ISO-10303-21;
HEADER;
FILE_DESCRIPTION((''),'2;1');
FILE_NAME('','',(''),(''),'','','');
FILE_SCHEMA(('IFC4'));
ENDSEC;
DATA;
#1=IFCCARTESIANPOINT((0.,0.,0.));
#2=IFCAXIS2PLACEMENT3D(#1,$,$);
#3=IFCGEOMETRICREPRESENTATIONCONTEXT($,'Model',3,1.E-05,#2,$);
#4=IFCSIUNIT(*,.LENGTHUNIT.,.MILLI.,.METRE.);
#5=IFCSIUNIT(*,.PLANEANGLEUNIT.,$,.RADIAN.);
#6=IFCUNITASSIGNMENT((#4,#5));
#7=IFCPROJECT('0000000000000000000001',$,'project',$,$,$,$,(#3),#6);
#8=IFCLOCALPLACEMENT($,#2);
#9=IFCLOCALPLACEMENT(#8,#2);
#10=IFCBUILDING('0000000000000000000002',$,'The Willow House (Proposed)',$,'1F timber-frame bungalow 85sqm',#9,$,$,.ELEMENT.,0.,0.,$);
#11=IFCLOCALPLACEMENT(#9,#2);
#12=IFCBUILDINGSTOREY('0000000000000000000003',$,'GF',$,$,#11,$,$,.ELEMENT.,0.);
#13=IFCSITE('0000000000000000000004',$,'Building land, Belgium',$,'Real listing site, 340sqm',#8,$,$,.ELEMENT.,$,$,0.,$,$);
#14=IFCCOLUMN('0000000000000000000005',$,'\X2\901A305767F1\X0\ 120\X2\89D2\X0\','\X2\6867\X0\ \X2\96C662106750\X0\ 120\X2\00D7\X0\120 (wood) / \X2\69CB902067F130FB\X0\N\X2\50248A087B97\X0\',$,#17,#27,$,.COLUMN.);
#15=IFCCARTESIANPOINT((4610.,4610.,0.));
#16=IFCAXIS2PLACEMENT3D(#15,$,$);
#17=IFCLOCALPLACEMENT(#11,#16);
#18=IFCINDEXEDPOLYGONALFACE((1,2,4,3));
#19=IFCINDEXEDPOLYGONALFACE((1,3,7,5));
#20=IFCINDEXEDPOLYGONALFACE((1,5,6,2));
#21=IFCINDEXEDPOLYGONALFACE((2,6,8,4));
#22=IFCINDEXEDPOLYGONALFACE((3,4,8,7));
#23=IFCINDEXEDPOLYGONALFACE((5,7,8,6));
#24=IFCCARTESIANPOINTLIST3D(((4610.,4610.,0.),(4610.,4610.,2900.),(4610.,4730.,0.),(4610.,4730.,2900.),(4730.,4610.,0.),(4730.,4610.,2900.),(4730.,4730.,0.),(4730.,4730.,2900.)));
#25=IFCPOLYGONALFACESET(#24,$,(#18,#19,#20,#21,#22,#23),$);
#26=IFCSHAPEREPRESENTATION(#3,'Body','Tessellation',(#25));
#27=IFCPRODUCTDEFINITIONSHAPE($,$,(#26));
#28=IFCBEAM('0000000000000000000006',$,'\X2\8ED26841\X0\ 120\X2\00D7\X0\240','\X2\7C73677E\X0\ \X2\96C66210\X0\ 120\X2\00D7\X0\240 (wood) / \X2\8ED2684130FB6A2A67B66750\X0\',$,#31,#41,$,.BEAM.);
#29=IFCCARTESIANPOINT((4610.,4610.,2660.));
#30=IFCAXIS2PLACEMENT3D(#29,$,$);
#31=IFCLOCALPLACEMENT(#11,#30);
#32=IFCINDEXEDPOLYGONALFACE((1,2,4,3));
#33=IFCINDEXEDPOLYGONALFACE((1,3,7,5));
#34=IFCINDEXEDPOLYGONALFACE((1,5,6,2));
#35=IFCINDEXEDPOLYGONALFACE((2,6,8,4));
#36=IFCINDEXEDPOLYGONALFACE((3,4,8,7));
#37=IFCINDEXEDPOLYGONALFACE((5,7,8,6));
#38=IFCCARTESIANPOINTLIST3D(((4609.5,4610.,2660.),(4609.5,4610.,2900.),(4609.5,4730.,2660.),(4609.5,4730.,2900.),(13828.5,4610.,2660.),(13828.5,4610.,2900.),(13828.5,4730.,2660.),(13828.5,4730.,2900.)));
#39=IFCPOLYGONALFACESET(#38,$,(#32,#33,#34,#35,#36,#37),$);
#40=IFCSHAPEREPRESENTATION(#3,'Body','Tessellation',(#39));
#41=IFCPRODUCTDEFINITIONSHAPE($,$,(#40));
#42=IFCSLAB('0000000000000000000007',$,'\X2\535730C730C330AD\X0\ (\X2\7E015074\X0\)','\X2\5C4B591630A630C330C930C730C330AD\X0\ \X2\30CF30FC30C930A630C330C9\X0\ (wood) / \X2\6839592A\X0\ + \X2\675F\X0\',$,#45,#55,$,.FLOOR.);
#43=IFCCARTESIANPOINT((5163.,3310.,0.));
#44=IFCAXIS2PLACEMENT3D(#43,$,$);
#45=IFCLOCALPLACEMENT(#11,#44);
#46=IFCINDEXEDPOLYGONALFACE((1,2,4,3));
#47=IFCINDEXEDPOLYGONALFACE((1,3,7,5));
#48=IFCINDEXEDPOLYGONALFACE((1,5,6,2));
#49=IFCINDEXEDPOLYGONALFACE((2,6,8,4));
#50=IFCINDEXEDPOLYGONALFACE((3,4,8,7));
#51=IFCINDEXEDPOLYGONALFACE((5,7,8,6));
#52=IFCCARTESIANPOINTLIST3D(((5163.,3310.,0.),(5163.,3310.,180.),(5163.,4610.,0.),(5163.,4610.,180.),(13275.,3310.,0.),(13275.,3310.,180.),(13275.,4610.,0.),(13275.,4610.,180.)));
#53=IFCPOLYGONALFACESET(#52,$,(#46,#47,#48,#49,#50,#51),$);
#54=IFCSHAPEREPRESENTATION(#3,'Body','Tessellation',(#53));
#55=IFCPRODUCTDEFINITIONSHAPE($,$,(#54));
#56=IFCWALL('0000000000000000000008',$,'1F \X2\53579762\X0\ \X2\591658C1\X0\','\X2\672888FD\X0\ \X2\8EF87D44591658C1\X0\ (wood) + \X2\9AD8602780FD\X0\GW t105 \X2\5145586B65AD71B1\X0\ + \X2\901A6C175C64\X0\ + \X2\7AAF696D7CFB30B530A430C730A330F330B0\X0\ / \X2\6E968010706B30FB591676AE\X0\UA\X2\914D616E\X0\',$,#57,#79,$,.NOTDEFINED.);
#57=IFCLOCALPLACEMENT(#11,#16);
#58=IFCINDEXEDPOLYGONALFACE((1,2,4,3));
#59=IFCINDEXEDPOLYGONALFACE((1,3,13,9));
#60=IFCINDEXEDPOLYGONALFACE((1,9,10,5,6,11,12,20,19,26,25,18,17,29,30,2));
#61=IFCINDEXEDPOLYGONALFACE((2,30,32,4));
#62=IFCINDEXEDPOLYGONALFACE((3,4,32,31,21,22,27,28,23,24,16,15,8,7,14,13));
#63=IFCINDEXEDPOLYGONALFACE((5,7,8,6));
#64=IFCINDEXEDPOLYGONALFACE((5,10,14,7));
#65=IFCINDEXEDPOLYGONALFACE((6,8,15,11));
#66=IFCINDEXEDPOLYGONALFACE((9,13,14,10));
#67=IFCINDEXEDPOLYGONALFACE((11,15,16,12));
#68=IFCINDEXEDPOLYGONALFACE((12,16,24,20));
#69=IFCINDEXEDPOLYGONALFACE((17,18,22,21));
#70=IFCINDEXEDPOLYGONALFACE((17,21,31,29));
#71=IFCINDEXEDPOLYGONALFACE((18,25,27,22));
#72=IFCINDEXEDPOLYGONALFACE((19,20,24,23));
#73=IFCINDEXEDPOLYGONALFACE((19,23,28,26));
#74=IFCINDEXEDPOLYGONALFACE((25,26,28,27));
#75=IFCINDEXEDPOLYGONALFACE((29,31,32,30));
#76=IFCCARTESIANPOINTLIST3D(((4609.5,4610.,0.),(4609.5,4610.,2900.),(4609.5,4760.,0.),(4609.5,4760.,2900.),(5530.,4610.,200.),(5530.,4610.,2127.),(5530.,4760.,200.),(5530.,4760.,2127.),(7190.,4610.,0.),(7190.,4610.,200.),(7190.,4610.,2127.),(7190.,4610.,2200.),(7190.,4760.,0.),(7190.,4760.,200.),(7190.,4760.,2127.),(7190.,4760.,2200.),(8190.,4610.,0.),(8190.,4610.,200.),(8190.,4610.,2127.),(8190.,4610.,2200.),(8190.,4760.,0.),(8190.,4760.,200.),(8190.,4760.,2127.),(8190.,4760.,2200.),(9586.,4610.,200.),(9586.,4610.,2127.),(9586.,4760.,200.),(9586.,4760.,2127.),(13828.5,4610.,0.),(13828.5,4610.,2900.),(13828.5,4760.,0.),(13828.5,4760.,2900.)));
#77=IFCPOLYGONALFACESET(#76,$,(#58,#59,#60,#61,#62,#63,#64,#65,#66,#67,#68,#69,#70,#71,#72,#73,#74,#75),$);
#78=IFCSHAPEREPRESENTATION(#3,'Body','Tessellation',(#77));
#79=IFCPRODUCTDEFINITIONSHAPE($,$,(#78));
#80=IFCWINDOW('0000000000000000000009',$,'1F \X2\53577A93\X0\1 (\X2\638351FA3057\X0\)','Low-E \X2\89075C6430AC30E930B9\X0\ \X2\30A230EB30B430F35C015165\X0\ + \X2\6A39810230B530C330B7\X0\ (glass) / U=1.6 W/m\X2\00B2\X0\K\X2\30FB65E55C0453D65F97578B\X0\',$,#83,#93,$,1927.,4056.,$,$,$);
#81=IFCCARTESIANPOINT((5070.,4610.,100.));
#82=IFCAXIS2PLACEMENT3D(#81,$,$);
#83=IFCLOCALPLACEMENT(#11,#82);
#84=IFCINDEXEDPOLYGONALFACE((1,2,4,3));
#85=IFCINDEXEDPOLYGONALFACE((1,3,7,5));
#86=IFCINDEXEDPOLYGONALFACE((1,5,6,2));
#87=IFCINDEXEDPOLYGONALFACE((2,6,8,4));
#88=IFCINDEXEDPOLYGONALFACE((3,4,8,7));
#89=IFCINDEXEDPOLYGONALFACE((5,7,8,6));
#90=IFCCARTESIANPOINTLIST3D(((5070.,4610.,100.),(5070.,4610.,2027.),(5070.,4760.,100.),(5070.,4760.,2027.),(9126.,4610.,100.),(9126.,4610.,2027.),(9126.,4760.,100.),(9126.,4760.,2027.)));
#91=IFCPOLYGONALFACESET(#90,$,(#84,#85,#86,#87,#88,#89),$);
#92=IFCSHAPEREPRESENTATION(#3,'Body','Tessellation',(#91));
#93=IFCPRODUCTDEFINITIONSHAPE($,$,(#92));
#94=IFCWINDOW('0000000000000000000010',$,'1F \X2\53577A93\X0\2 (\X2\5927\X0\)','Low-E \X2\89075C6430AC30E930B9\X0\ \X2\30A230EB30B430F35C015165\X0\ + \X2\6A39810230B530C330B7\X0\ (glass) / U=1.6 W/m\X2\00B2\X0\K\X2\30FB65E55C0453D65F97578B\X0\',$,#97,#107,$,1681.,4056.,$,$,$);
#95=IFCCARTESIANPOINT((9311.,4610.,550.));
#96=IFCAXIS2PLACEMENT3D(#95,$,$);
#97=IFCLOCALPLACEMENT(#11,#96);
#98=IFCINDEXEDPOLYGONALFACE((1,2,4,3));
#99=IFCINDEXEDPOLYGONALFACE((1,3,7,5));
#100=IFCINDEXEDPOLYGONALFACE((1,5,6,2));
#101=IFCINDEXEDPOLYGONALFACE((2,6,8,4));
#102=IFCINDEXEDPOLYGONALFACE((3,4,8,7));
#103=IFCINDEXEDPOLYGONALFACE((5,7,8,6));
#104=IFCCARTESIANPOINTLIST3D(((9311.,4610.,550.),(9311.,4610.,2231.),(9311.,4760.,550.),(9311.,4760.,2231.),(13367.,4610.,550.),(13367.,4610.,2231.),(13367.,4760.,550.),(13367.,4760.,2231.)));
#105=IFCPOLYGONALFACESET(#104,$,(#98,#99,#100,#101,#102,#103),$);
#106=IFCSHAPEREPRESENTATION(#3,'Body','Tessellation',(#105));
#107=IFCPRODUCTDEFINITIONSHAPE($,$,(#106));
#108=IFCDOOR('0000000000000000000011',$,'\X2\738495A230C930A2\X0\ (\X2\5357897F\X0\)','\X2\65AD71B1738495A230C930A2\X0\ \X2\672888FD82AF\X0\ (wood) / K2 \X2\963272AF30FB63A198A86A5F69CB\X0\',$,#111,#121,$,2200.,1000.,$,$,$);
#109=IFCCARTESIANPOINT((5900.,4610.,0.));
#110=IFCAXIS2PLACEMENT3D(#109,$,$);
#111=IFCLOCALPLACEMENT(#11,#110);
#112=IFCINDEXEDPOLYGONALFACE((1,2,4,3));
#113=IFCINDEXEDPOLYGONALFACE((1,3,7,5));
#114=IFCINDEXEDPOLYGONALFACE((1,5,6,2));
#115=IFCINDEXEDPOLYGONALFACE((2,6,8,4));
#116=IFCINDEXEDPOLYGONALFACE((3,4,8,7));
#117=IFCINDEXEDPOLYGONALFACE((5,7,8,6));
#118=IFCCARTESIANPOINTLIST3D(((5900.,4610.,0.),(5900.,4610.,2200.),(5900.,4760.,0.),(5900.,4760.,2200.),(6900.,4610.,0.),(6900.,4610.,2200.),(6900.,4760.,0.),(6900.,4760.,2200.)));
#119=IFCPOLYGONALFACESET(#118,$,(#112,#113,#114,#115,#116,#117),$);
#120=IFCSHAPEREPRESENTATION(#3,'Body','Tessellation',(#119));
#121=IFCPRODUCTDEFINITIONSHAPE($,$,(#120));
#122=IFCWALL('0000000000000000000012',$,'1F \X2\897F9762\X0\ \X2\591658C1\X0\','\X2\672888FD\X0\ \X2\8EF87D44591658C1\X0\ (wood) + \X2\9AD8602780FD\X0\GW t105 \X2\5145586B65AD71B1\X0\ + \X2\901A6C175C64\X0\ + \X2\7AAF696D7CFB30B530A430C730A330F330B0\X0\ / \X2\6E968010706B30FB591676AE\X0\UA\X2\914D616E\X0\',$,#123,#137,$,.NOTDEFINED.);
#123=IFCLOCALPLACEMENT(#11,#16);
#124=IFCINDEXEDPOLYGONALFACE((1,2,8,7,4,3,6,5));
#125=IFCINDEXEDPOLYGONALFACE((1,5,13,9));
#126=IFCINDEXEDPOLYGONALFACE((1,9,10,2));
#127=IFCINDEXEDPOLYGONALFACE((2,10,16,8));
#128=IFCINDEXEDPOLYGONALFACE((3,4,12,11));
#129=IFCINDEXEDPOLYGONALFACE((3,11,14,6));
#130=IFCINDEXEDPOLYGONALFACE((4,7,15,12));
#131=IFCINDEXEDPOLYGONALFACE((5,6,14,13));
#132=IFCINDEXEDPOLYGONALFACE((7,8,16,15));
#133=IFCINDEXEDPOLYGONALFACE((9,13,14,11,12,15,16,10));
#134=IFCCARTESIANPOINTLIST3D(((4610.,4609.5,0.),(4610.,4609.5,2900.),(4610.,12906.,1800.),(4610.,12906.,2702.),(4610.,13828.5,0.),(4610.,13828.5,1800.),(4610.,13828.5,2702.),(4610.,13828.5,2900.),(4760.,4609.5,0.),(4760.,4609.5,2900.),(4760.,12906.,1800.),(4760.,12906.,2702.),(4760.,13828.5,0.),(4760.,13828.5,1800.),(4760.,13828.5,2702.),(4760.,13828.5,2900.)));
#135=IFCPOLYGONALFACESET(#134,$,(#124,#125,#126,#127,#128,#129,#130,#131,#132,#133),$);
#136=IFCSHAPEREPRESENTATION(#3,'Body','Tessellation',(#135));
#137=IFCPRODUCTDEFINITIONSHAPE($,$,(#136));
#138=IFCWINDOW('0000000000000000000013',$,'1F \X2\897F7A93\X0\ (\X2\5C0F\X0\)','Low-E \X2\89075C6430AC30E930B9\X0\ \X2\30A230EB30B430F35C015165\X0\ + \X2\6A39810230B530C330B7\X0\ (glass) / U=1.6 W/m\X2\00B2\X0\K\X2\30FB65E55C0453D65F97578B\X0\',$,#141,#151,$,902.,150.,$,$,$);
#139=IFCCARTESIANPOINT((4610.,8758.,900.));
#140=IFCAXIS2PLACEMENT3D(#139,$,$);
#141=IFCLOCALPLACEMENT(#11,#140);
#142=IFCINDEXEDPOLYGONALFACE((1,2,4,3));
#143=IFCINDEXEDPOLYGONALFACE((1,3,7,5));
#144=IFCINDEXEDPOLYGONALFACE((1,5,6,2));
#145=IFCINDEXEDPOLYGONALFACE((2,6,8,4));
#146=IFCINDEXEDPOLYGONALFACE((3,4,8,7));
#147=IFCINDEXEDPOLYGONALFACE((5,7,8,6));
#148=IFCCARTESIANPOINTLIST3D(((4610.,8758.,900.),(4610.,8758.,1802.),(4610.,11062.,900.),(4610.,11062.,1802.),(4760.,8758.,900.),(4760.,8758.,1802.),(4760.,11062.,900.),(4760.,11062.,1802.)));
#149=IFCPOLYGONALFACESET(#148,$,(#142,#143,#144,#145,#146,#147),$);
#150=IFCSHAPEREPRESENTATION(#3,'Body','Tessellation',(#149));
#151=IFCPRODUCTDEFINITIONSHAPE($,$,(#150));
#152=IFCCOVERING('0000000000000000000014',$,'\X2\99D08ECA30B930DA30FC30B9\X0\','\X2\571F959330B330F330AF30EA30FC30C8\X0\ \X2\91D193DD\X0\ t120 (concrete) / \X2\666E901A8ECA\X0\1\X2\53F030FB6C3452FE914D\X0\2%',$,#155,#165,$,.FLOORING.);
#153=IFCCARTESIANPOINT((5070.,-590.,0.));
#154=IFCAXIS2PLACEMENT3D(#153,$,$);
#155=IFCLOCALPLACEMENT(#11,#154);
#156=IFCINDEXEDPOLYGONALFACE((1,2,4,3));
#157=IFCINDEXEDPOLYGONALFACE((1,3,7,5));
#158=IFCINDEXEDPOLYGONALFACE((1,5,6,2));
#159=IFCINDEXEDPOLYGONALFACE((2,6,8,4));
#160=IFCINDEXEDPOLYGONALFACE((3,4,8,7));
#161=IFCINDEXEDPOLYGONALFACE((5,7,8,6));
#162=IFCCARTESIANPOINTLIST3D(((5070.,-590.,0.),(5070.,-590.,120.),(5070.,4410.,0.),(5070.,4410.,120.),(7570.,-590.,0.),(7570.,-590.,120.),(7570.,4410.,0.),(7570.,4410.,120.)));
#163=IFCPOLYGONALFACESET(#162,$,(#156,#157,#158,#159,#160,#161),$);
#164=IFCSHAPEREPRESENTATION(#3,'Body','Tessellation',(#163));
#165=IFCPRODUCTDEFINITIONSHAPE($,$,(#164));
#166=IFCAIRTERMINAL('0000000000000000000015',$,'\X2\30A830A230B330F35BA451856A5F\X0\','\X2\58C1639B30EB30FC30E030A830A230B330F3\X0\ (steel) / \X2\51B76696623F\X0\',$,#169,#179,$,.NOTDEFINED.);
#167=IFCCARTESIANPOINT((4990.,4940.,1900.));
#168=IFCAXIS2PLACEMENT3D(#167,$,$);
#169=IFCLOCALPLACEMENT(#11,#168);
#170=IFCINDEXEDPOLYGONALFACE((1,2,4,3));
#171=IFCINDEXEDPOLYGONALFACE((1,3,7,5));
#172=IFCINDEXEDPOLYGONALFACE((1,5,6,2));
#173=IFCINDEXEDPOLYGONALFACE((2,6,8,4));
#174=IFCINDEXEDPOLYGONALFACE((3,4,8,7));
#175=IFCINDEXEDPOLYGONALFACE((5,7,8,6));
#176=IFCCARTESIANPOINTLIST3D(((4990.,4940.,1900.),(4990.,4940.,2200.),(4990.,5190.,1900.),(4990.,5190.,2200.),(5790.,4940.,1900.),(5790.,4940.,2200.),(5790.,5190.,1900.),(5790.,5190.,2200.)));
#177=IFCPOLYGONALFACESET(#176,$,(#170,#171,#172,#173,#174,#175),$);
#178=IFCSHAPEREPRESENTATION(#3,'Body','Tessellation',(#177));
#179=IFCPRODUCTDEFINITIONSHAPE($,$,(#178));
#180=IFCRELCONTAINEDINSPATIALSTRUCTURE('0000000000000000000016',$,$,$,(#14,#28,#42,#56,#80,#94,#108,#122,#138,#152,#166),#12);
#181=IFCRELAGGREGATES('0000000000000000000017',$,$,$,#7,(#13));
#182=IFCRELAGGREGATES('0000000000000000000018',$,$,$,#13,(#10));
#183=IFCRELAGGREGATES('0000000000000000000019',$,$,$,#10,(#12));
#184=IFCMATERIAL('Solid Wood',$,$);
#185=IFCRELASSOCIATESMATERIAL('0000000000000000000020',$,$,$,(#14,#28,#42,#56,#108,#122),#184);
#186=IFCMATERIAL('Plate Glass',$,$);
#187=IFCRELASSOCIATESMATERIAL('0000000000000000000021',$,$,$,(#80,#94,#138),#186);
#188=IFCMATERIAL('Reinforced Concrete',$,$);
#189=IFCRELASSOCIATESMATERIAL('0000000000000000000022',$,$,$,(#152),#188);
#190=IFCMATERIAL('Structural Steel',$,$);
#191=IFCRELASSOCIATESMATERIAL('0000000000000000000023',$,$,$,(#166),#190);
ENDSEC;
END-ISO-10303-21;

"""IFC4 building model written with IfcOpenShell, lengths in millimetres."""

from ifc_helpers import new_model, si_unit, frame, frame_2d, origin, place, context, project, spatial, rectangle, extrude, material, element, fill, save


model = new_model("IFC4")

# Units and contexts
model_context = context("Model", 3, precision=1e-05, world=origin())
ifc_project = project(units=[si_unit("LENGTHUNIT", "METRE", prefix="MILLI"), si_unit("PLANEANGLEUNIT", "RADIAN")], contexts=[model_context])

# Site, building, storey
site_placement = place(None, origin())
site = spatial("IfcSite", under=ifc_project, at=site_placement, Name="Building land, Belgium", ObjectType="Real listing site, 340sqm", CompositionType="ELEMENT", RefElevation=0.0)
building_placement = place(site_placement, origin())
building = spatial("IfcBuilding", under=site, at=building_placement, Name="The Willow House (Proposed)", ObjectType="1F timber-frame bungalow 85sqm", CompositionType="ELEMENT", ElevationOfRefHeight=0.0, ElevationOfTerrain=0.0)
storey_placement = place(building_placement, origin())
storey = spatial("IfcBuildingStorey", under=building, at=storey_placement, Name="GF", CompositionType="ELEMENT", Elevation=0.0)

# Column
ifc_material_1 = material(Name="Solid Wood")
column_1_placement = place(storey_placement, frame((4610.0, 4610.0, 0.0)))
element("IfcColumn", 1, at=column_1_placement, inside=storey, material=ifc_material_1, Name="通し柱 120角", Description="桧 集成材 120×120 (wood) / 構造柱・N値計算", PredefinedType="COLUMN", context=model_context, shape_type="SweptSolid", body=[
    extrude(rectangle(XDim=120.0, YDim=120.0, at=frame_2d((60.0, 60.0))), frame((4610.0, 4610.0, 0.0)), (0.0, 0.0, 1.0), 2900.0),
])

# Beam
beam_1_placement = place(storey_placement, frame((4610.0, 4610.0, 2660.0)))
element("IfcBeam", 2, at=beam_1_placement, inside=storey, material=ifc_material_1, Name="軒桁 120×240", Description="米松 集成 120×240 (wood) / 軒桁・横架材", PredefinedType="BEAM", context=model_context, shape_type="SweptSolid", body=[
    extrude(rectangle(XDim=9219.0, YDim=120.0, at=frame_2d((4609.0, 60.0))), frame((4610.0, 4610.0, 2660.0)), (0.0, 0.0, 1.0), 240.0),
])

# Slab
ifc_material_2 = material(Name="Reinforced Concrete")
slab_1_placement = place(storey_placement, frame((5163.0, 3310.0, 0.0)))
element("IfcSlab", 3, at=slab_1_placement, inside=storey, material=ifc_material_1, Name="南デッキ (縁側)", Description="屋外ウッドデッキ ハードウッド (wood) / 根太 + 束", PredefinedType="FLOOR", context=model_context, shape_type="SweptSolid", body=[
    extrude(rectangle(XDim=8112.0, YDim=1300.0, at=frame_2d((4056.0, 650.0))), frame((5163.0, 3310.0, 0.0)), (0.0, 0.0, 1.0), 180.0),
])

# Wall, openings, windows, door
wall_1_placement = place(storey_placement, frame((4610.0, 4610.0, 0.0)))
wall_1 = element("IfcWall", 4, at=wall_1_placement, inside=storey, material=ifc_material_1, Name="1F 南面 外壁", Description="木製 軸組外壁 (wood) + 高性能GW t105 充填断熱 + 通気層 + 窯業系サイディング / 準耐火・外皮UA配慮", PredefinedType="NOTDEFINED", context=model_context, shape_type="SweptSolid", body=[
    extrude(rectangle(XDim=9219.0, YDim=150.0, at=frame_2d((4609.0, 75.0))), frame((4610.0, 4610.0, 0.0)), (0.0, 0.0, 1.0), 2900.0),
])
opening_1_placement = place(storey_placement, frame((5070.0, 4610.0, 100.0)))
opening_1 = element("IfcOpeningElement", 5, at=opening_1_placement, cuts=wall_1, PredefinedType="NOTDEFINED", context=model_context, shape_type="SweptSolid", body=[
    extrude(rectangle(XDim=4056.0, YDim=150.0, at=frame_2d((2028.0, 75.0))), frame((5070.0, 4610.0, 100.0)), (0.0, 0.0, 1.0), 1927.0),
])
opening_2_placement = place(storey_placement, frame((9311.0, 4610.0, 550.0)))
opening_2 = element("IfcOpeningElement", 6, at=opening_2_placement, cuts=wall_1, PredefinedType="NOTDEFINED", context=model_context, shape_type="SweptSolid", body=[
    extrude(rectangle(XDim=4056.0, YDim=150.0, at=frame_2d((2028.0, 75.0))), frame((9311.0, 4610.0, 550.0)), (0.0, 0.0, 1.0), 1681.0),
])
opening_3_placement = place(storey_placement, frame((5900.0, 4610.0, 0.0)))
opening_3 = element("IfcOpeningElement", 7, at=opening_3_placement, cuts=wall_1, PredefinedType="NOTDEFINED", context=model_context, shape_type="SweptSolid", body=[
    extrude(rectangle(XDim=1000.0, YDim=150.0, at=frame_2d((500.0, 75.0))), frame((5900.0, 4610.0, 0.0)), (0.0, 0.0, 1.0), 2200.0),
])
ifc_material_3 = material(Name="Plate Glass")
window_1_placement = place(storey_placement, frame((5070.0, 4610.0, 100.0)))
window_1 = element("IfcWindow", 8, at=window_1_placement, inside=storey, material=ifc_material_3, Name="1F 南窓1 (掃出し)", Description="Low-E 複層ガラス アルゴン封入 + 樹脂サッシ (glass) / U=1.6 W/m²K・日射取得型", OverallHeight=1927.0, OverallWidth=4056.0, context=model_context, shape_type="SweptSolid", body=[
    extrude(rectangle(XDim=4056.0, YDim=150.0, at=frame_2d((2028.0, 75.0))), frame((5070.0, 4610.0, 100.0)), (0.0, 0.0, 1.0), 1927.0),
])
fill(opening_1, window_1)
window_2_placement = place(storey_placement, frame((9311.0, 4610.0, 550.0)))
window_2 = element("IfcWindow", 9, at=window_2_placement, inside=storey, material=ifc_material_3, Name="1F 南窓2 (大)", Description="Low-E 複層ガラス アルゴン封入 + 樹脂サッシ (glass) / U=1.6 W/m²K・日射取得型", OverallHeight=1681.0, OverallWidth=4056.0, context=model_context, shape_type="SweptSolid", body=[
    extrude(rectangle(XDim=4056.0, YDim=150.0, at=frame_2d((2028.0, 75.0))), frame((9311.0, 4610.0, 550.0)), (0.0, 0.0, 1.0), 1681.0),
])
fill(opening_2, window_2)
door_placement = place(storey_placement, frame((5900.0, 4610.0, 0.0)))
door = element("IfcDoor", 10, at=door_placement, inside=storey, material=ifc_material_1, Name="玄関ドア (南西)", Description="断熱玄関ドア 木製芯 (wood) / K2 防犯・採風機構", OverallHeight=2200.0, OverallWidth=1000.0, context=model_context, shape_type="SweptSolid", body=[
    extrude(rectangle(XDim=1000.0, YDim=150.0, at=frame_2d((500.0, 75.0))), frame((5900.0, 4610.0, 0.0)), (0.0, 0.0, 1.0), 2200.0),
])
fill(opening_3, door)

# Wall, opening, window
wall_2_placement = place(storey_placement, frame((4610.0, 4610.0, 0.0)))
wall_2 = element("IfcWall", 11, at=wall_2_placement, inside=storey, material=ifc_material_1, Name="1F 西面 外壁", Description="木製 軸組外壁 (wood) + 高性能GW t105 充填断熱 + 通気層 + 窯業系サイディング / 準耐火・外皮UA配慮", PredefinedType="NOTDEFINED", context=model_context, shape_type="SweptSolid", body=[
    extrude(rectangle(XDim=150.0, YDim=9219.0, at=frame_2d((75.0, 4609.0))), frame((4610.0, 4610.0, 0.0)), (0.0, 0.0, 1.0), 2900.0),
])
opening_4_placement = place(storey_placement, frame((4610.0, 8758.0, 900.0)))
opening_4 = element("IfcOpeningElement", 12, at=opening_4_placement, cuts=wall_2, PredefinedType="NOTDEFINED", context=model_context, shape_type="SweptSolid", body=[
    extrude(rectangle(XDim=150.0, YDim=2304.0, at=frame_2d((75.0, 1152.0))), frame((4610.0, 8758.0, 900.0)), (0.0, 0.0, 1.0), 902.0),
])
window_3_placement = place(storey_placement, frame((4610.0, 8758.0, 900.0)))
window_3 = element("IfcWindow", 13, at=window_3_placement, inside=storey, material=ifc_material_3, Name="1F 西窓 (小)", Description="Low-E 複層ガラス アルゴン封入 + 樹脂サッシ (glass) / U=1.6 W/m²K・日射取得型", OverallHeight=902.0, OverallWidth=150.0, context=model_context, shape_type="SweptSolid", body=[
    extrude(rectangle(XDim=150.0, YDim=2304.0, at=frame_2d((75.0, 1152.0))), frame((4610.0, 8758.0, 900.0)), (0.0, 0.0, 1.0), 902.0),
])
fill(opening_4, window_3)

# Shared definitions
ifc_material_4 = material(Name="Structural Steel")

# Covering
covering_1_placement = place(storey_placement, frame((5070.0, -590.0, 0.0)))
element("IfcCovering", 14, at=covering_1_placement, inside=storey, material=ifc_material_2, Name="駐車スペース", Description="土間コンクリート 金鏝 t120 (concrete) / 普通車1台・水勾配2%", PredefinedType="FLOORING", context=model_context, shape_type="SweptSolid", body=[
    extrude(rectangle(XDim=2500.0, YDim=5000.0, at=frame_2d((1250.0, 2500.0))), frame((5070.0, -590.0, 0.0)), (0.0, 0.0, 1.0), 120.0),
])

# Air terminal
air_terminal_placement = place(storey_placement, frame((4990.0, 4940.0, 1900.0)))
element("IfcAirTerminal", 15, at=air_terminal_placement, inside=storey, material=ifc_material_4, Name="エアコン室内機", Description="壁掛ルームエアコン (steel) / 冷暖房", PredefinedType="NOTDEFINED", context=model_context, shape_type="SweptSolid", body=[
    extrude(rectangle(XDim=800.0, YDim=250.0, at=frame_2d((400.0, 125.0))), frame((4990.0, 4940.0, 1900.0)), (0.0, 0.0, 1.0), 300.0),
])

save(model, "model.ifc")
